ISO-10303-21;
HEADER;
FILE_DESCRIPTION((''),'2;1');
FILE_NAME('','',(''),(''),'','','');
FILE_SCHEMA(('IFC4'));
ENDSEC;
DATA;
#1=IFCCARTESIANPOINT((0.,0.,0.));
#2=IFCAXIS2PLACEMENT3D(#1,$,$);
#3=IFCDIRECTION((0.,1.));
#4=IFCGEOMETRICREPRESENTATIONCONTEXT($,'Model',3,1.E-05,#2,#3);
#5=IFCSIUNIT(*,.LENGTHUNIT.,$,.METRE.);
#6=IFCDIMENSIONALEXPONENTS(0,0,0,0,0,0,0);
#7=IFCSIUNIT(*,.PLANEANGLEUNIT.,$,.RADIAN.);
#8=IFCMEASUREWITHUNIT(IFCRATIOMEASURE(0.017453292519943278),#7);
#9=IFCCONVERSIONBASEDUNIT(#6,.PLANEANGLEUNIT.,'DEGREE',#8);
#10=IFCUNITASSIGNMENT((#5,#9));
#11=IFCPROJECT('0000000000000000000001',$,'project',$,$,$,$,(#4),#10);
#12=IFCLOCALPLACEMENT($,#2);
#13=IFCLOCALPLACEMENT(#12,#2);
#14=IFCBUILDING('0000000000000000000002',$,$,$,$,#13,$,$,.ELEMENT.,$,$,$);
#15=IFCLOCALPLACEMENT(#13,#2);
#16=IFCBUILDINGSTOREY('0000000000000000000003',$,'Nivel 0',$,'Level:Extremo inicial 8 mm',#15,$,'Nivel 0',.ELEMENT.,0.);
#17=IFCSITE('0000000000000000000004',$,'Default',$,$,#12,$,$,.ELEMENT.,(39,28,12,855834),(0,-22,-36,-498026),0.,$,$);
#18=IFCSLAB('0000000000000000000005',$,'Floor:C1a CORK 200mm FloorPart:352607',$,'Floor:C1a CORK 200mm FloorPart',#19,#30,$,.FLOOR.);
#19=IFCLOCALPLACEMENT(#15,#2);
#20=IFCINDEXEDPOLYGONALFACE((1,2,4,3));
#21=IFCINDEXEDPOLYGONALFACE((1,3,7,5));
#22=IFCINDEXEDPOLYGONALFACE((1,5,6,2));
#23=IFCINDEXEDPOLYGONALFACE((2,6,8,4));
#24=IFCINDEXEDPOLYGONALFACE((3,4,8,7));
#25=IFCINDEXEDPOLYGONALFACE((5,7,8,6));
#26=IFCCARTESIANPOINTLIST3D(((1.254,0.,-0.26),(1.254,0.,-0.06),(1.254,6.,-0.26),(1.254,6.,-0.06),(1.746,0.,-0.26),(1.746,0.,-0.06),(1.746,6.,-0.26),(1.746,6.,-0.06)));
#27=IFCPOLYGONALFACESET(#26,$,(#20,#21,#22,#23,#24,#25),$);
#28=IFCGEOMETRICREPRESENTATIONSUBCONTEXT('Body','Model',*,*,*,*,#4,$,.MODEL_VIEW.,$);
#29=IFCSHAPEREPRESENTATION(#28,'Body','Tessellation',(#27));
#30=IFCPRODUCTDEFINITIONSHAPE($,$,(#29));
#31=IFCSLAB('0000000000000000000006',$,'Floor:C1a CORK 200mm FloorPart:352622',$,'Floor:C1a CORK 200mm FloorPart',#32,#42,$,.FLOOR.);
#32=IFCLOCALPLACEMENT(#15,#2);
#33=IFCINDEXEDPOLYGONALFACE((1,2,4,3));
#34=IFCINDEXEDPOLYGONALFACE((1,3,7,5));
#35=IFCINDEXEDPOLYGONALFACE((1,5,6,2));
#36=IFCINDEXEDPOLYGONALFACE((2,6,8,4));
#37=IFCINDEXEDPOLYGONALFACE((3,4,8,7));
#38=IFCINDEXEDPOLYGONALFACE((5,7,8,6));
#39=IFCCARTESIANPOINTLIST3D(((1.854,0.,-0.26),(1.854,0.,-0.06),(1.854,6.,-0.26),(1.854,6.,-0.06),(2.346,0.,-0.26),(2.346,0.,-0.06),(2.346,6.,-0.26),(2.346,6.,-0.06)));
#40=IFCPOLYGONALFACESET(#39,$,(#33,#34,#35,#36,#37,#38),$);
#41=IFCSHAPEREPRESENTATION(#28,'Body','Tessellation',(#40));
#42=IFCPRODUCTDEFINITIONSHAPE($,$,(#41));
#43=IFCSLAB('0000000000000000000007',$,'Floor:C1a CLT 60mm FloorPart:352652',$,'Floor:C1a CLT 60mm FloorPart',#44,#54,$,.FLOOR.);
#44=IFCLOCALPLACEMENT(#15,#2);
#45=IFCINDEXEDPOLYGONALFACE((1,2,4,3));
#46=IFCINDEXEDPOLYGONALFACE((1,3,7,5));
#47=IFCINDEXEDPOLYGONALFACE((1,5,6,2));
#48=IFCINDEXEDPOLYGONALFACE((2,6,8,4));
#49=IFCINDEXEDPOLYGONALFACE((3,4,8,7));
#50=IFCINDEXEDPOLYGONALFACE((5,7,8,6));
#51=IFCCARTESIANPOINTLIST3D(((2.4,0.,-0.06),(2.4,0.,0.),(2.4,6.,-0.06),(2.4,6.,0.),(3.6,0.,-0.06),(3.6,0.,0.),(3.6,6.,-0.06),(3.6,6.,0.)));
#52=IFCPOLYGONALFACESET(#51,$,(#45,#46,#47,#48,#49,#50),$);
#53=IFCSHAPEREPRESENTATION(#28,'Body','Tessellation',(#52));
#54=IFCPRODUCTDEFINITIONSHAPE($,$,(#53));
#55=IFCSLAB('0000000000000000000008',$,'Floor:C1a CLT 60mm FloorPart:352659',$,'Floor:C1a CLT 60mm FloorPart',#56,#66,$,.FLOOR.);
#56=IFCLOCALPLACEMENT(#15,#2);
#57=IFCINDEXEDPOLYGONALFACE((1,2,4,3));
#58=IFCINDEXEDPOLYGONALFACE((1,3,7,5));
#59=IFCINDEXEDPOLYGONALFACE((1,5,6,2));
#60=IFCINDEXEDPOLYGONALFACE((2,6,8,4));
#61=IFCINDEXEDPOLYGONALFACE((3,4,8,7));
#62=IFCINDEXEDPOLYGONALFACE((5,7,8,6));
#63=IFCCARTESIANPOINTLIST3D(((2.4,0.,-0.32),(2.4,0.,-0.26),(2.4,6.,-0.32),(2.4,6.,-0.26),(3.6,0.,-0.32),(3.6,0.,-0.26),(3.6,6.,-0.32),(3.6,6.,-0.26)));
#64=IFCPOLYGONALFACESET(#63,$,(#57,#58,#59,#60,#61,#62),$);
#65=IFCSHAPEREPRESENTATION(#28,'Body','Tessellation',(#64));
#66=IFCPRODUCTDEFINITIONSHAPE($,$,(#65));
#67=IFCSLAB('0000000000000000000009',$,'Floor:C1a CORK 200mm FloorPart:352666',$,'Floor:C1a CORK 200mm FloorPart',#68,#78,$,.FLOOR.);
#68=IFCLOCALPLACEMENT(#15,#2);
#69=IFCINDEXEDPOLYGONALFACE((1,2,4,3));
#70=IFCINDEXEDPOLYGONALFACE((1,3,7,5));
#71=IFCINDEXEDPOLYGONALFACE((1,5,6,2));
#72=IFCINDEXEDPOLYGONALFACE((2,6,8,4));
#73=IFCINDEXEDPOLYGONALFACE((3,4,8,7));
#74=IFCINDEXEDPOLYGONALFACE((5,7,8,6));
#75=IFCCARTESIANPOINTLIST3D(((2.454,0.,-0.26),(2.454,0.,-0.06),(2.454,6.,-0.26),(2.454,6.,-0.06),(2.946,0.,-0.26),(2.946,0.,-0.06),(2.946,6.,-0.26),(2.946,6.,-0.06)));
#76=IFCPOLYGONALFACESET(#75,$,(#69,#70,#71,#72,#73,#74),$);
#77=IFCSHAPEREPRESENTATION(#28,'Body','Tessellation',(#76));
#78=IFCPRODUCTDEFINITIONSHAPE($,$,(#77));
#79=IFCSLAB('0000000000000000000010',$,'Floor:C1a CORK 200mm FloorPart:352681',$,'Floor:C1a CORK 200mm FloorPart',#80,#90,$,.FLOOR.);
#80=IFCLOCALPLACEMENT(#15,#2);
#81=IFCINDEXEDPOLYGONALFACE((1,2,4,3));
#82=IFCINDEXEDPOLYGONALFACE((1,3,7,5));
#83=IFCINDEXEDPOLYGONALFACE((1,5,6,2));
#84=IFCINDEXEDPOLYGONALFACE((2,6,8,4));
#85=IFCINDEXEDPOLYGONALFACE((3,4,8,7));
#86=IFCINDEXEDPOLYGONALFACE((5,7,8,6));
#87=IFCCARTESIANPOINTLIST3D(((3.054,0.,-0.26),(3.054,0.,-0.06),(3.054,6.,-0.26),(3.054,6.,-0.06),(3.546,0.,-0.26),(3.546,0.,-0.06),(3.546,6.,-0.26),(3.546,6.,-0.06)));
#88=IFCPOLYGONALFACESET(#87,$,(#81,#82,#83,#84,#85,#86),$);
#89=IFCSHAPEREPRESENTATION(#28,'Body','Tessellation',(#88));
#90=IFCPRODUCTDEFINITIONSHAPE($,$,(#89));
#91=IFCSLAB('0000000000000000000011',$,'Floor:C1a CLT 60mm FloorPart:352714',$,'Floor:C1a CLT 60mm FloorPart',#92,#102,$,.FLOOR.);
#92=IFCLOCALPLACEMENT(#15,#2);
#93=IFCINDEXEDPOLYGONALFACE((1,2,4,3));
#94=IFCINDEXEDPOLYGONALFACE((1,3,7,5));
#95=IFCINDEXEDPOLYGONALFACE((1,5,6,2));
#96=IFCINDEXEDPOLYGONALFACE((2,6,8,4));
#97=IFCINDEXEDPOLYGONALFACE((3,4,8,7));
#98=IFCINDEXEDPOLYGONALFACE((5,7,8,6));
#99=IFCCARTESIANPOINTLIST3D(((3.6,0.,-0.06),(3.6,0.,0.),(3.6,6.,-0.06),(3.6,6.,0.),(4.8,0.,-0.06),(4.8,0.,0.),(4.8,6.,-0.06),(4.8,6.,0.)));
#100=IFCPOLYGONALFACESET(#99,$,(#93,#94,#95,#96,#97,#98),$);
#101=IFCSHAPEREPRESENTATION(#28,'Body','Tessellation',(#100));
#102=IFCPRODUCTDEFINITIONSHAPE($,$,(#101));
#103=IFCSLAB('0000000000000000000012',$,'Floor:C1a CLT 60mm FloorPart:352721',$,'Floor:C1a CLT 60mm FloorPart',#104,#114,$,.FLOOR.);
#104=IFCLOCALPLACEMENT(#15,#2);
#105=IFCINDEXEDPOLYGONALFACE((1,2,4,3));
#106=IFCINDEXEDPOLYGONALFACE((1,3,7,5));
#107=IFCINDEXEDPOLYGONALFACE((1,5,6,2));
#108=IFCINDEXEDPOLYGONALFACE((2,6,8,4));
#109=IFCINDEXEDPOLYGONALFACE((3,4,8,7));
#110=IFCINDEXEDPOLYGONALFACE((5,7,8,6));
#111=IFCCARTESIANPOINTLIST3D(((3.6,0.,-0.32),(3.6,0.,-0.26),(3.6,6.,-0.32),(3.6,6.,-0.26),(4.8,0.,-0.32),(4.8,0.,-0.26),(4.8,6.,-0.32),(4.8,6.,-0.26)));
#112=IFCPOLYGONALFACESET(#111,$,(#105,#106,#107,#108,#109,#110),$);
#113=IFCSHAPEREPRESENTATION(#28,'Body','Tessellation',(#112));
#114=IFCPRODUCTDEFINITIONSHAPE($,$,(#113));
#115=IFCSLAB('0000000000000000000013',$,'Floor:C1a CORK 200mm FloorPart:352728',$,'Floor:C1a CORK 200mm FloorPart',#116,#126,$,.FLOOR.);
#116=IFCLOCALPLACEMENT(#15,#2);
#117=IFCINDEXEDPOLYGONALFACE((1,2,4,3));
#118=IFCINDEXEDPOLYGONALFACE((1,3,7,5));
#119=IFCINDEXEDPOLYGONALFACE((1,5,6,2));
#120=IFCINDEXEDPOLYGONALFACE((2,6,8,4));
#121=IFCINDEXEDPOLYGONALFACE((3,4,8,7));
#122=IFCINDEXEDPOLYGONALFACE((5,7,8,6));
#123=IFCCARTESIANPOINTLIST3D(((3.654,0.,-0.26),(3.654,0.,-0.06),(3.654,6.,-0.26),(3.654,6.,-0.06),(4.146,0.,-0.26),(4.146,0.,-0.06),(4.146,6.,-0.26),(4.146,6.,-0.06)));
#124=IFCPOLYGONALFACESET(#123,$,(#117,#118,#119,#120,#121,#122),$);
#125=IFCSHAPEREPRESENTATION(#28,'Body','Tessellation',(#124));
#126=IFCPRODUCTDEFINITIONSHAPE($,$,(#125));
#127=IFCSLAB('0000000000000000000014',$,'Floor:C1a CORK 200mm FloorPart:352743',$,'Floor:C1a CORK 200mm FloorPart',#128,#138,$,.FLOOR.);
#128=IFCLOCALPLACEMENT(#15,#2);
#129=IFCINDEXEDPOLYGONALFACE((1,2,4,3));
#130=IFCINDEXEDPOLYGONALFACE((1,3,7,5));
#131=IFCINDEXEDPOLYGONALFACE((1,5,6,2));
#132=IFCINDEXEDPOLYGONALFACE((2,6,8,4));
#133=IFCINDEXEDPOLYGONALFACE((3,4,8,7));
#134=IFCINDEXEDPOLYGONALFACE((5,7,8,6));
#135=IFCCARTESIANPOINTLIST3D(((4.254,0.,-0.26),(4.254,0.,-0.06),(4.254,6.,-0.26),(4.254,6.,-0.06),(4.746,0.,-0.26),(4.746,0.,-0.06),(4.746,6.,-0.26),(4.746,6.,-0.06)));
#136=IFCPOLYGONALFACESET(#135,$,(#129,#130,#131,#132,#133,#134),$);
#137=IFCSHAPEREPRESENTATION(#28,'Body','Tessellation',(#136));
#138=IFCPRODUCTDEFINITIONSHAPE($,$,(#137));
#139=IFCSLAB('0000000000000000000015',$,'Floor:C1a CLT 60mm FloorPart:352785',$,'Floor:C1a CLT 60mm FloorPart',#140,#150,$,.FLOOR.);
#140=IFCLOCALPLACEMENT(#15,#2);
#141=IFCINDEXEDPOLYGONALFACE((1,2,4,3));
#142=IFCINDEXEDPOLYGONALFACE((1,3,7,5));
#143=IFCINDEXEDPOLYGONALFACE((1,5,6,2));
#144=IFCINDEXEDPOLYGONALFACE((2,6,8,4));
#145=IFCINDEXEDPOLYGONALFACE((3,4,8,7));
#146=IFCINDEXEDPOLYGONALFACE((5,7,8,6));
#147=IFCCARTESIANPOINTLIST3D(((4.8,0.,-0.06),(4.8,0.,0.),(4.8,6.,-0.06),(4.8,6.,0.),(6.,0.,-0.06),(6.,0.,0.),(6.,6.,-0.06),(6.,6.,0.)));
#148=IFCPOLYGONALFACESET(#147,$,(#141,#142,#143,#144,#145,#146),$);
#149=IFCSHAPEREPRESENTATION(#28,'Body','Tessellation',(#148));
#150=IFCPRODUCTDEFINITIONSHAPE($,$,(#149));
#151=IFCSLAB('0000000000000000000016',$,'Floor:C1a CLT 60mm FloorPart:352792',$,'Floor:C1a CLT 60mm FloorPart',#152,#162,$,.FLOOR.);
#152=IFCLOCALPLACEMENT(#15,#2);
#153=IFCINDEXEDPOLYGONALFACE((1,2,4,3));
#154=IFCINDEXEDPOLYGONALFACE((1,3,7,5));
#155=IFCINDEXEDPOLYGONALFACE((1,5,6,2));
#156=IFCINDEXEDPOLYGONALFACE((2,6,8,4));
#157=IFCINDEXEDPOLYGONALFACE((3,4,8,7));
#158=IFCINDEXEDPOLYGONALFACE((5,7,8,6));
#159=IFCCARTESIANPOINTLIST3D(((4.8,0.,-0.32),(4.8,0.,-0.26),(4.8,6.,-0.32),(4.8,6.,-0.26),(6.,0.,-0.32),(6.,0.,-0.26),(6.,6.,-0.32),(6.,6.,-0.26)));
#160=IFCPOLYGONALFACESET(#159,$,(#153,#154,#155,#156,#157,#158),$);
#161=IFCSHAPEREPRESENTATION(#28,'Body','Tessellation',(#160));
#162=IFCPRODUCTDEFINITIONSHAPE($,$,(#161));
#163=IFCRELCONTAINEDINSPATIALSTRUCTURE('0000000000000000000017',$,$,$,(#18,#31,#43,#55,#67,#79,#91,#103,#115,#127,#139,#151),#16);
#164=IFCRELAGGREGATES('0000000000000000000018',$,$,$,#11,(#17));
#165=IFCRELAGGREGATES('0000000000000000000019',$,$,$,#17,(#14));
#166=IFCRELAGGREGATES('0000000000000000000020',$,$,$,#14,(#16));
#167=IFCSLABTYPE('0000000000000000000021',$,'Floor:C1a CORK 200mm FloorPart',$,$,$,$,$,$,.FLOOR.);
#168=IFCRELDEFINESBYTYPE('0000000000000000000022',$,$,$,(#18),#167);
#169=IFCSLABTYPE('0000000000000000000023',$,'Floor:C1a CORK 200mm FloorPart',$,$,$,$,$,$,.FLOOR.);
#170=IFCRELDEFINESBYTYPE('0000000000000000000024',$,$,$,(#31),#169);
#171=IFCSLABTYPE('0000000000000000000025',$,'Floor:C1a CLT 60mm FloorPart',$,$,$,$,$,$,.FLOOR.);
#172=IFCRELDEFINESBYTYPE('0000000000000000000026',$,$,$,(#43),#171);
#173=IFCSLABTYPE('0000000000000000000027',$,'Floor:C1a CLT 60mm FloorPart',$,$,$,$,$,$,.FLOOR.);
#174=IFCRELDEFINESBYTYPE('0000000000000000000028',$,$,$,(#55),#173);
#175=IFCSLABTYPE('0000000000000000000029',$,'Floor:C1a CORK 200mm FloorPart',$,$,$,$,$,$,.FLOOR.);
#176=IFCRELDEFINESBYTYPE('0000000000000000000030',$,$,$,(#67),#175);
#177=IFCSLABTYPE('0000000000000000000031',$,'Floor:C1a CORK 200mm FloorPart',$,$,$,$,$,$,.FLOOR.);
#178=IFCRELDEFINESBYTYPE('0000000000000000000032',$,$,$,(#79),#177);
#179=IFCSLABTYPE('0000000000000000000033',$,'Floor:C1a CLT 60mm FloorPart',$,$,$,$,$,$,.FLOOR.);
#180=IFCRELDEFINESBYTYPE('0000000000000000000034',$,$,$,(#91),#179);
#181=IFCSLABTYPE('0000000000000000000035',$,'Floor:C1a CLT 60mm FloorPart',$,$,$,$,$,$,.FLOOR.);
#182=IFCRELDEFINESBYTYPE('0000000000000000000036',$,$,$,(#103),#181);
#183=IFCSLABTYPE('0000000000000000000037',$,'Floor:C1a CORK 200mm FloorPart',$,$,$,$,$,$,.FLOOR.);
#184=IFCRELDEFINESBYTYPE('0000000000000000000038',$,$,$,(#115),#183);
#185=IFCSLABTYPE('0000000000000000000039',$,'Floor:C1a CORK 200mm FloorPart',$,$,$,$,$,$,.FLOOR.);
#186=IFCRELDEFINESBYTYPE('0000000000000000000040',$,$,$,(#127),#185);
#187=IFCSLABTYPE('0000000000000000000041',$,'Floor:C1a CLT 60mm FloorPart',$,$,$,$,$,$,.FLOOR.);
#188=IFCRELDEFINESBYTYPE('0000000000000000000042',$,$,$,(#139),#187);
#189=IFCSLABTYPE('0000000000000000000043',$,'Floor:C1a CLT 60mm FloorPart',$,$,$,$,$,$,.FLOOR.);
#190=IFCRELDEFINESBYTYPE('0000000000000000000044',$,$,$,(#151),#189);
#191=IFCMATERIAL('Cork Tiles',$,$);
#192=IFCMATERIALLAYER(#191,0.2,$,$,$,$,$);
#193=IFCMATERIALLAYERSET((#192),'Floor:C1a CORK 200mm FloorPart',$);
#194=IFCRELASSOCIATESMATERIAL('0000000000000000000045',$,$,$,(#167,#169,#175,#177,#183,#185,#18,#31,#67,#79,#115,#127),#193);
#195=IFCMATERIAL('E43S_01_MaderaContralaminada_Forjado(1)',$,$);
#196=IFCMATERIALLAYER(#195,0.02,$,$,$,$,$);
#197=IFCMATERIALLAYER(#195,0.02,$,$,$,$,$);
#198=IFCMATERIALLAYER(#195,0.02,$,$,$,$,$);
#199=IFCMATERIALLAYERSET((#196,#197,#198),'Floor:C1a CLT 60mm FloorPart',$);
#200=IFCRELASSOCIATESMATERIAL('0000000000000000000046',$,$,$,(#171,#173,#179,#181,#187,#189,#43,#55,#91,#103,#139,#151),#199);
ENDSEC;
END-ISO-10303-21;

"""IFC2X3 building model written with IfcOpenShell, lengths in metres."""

from ifc_helpers import new_model, entity, si_unit, converted_unit, direction, frame, frame_2d, origin, place, context, subcontext, project, spatial, rectangle, extrude, material, layer, layer_set, layer_usage, type_object, element, save


model = new_model("IFC2X3")

# Units and contexts
model_context = context("Model", 3, precision=1e-05, world=origin(), true_north=direction((0.0, 1.0)))
body_context = subcontext(model_context, "Body", "Model", "MODEL_VIEW")
ifc_project = project(units=[si_unit("LENGTHUNIT", "METRE"), converted_unit("PLANEANGLEUNIT", "DEGREE", entity("IfcRatioMeasure", 0.017453292519943278), si_unit("PLANEANGLEUNIT", "RADIAN"), dimensions=[0, 0, 0, 0, 0, 0, 0])], contexts=[model_context])

# Site, building, storey
site_placement = place(None, origin())
site = spatial("IfcSite", under=ifc_project, at=site_placement, Name="Default", CompositionType="ELEMENT", RefLatitude=(39, 28, 12, 855834), RefLongitude=(0, -22, -36, -498026), RefElevation=0.0)
building_placement = place(site_placement, origin())
building = spatial("IfcBuilding", under=site, at=building_placement, CompositionType="ELEMENT")
storey_placement = place(building_placement, origin())
storey = spatial("IfcBuildingStorey", under=building, at=storey_placement, Name="Nivel 0", ObjectType="Level:Extremo inicial 8 mm", LongName="Nivel 0", CompositionType="ELEMENT", Elevation=0.0)

# Shared definitions
ifc_material_1 = material(Name="E43S_01_MaderaContralaminada_Forjado(1)")

# Slabs
ifc_layer_1 = layer(ifc_material_1, 0.02)
ifc_layer_2 = layer(ifc_material_1, 0.02)
ifc_layer_3 = layer(ifc_material_1, 0.02)
ifc_layer_set_1 = layer_set([ifc_layer_1, ifc_layer_2, ifc_layer_3], Name="Floor:C1a CLT 60mm FloorPart")
ifc_material_2 = material(Name="Cork Tiles")
ifc_layer_4 = layer(ifc_material_2, 0.2)
ifc_layer_set_2 = layer_set([ifc_layer_4], Name="Floor:C1a CORK 200mm FloorPart")
ifc_layer_usage_1 = layer_usage(ifc_layer_set_2, "AXIS3", "POSITIVE", 0.0)
slab_type_1 = type_object("IfcSlabType", Name="Floor:C1a CORK 200mm FloorPart", PredefinedType="FLOOR", material=ifc_layer_set_2)
slab_1_placement = place(storey_placement, origin())
element("IfcSlab", 1, at=slab_1_placement, inside=storey, type_object=slab_type_1, material=ifc_layer_usage_1, Name="Floor:C1a CORK 200mm FloorPart:352607", ObjectType="Floor:C1a CORK 200mm FloorPart", PredefinedType="FLOOR", context=body_context, shape_type="SweptSolid", body=[
    extrude(rectangle(XDim=6.0, YDim=0.492, at=frame_2d((0.0, 0.0), x_axis=(1.0, 0.0))), frame((1.5, 3.0, -0.06), z_axis=(0.0, 0.0, -1.0), x_axis=(0.0, 1.0, 0.0)), (0.0, 0.0, 1.0), 0.2),
])
ifc_layer_usage_2 = layer_usage(ifc_layer_set_2, "AXIS3", "POSITIVE", 0.0)
slab_type_2 = type_object("IfcSlabType", Name="Floor:C1a CORK 200mm FloorPart", PredefinedType="FLOOR", material=ifc_layer_set_2)
slab_2_placement = place(storey_placement, origin())
element("IfcSlab", 2, at=slab_2_placement, inside=storey, type_object=slab_type_2, material=ifc_layer_usage_2, Name="Floor:C1a CORK 200mm FloorPart:352622", ObjectType="Floor:C1a CORK 200mm FloorPart", PredefinedType="FLOOR", context=body_context, shape_type="SweptSolid", body=[
    extrude(rectangle(XDim=6.0, YDim=0.492, at=frame_2d((0.0, 0.0), x_axis=(1.0, 0.0))), frame((2.1, 3.0, -0.06), z_axis=(0.0, 0.0, -1.0), x_axis=(0.0, 1.0, 0.0)), (0.0, 0.0, 1.0), 0.2),
])
ifc_layer_usage_3 = layer_usage(ifc_layer_set_1, "AXIS3", "POSITIVE", 0.0)
slab_type_3 = type_object("IfcSlabType", Name="Floor:C1a CLT 60mm FloorPart", PredefinedType="FLOOR", material=ifc_layer_set_1)
slab_3_placement = place(storey_placement, origin())
element("IfcSlab", 3, at=slab_3_placement, inside=storey, type_object=slab_type_3, material=ifc_layer_usage_3, Name="Floor:C1a CLT 60mm FloorPart:352652", ObjectType="Floor:C1a CLT 60mm FloorPart", PredefinedType="FLOOR", context=body_context, shape_type="SweptSolid", body=[
    extrude(rectangle(XDim=6.0, YDim=1.2, at=frame_2d((0.0, 0.0), x_axis=(1.0, 0.0))), frame((3.0, 3.0, 0.0), z_axis=(0.0, 0.0, -1.0), x_axis=(0.0, 1.0, 0.0)), (0.0, 0.0, 1.0), 0.06),
])
ifc_layer_usage_4 = layer_usage(ifc_layer_set_1, "AXIS3", "POSITIVE", 0.0)
slab_type_4 = type_object("IfcSlabType", Name="Floor:C1a CLT 60mm FloorPart", PredefinedType="FLOOR", material=ifc_layer_set_1)
slab_4_placement = place(storey_placement, origin())
element("IfcSlab", 4, at=slab_4_placement, inside=storey, type_object=slab_type_4, material=ifc_layer_usage_4, Name="Floor:C1a CLT 60mm FloorPart:352659", ObjectType="Floor:C1a CLT 60mm FloorPart", PredefinedType="FLOOR", context=body_context, shape_type="SweptSolid", body=[
    extrude(rectangle(XDim=6.0, YDim=1.2, at=frame_2d((0.0, 0.0), x_axis=(1.0, 0.0))), frame((3.0, 3.0, -0.26), z_axis=(0.0, 0.0, -1.0), x_axis=(0.0, 1.0, 0.0)), (0.0, 0.0, 1.0), 0.06),
])
ifc_layer_usage_5 = layer_usage(ifc_layer_set_2, "AXIS3", "POSITIVE", 0.0)
slab_type_5 = type_object("IfcSlabType", Name="Floor:C1a CORK 200mm FloorPart", PredefinedType="FLOOR", material=ifc_layer_set_2)
slab_5_placement = place(storey_placement, origin())
element("IfcSlab", 5, at=slab_5_placement, inside=storey, type_object=slab_type_5, material=ifc_layer_usage_5, Name="Floor:C1a CORK 200mm FloorPart:352666", ObjectType="Floor:C1a CORK 200mm FloorPart", PredefinedType="FLOOR", context=body_context, shape_type="SweptSolid", body=[
    extrude(rectangle(XDim=6.0, YDim=0.492, at=frame_2d((0.0, 0.0), x_axis=(1.0, 0.0))), frame((2.7, 3.0, -0.06), z_axis=(0.0, 0.0, -1.0), x_axis=(0.0, 1.0, 0.0)), (0.0, 0.0, 1.0), 0.2),
])
ifc_layer_usage_6 = layer_usage(ifc_layer_set_2, "AXIS3", "POSITIVE", 0.0)
slab_type_6 = type_object("IfcSlabType", Name="Floor:C1a CORK 200mm FloorPart", PredefinedType="FLOOR", material=ifc_layer_set_2)
slab_6_placement = place(storey_placement, origin())
element("IfcSlab", 6, at=slab_6_placement, inside=storey, type_object=slab_type_6, material=ifc_layer_usage_6, Name="Floor:C1a CORK 200mm FloorPart:352681", ObjectType="Floor:C1a CORK 200mm FloorPart", PredefinedType="FLOOR", context=body_context, shape_type="SweptSolid", body=[
    extrude(rectangle(XDim=6.0, YDim=0.492, at=frame_2d((0.0, 0.0), x_axis=(1.0, 0.0))), frame((3.3, 3.0, -0.06), z_axis=(0.0, 0.0, -1.0), x_axis=(0.0, 1.0, 0.0)), (0.0, 0.0, 1.0), 0.2),
])
ifc_layer_usage_7 = layer_usage(ifc_layer_set_1, "AXIS3", "POSITIVE", 0.0)
slab_type_7 = type_object("IfcSlabType", Name="Floor:C1a CLT 60mm FloorPart", PredefinedType="FLOOR", material=ifc_layer_set_1)
slab_7_placement = place(storey_placement, origin())
element("IfcSlab", 7, at=slab_7_placement, inside=storey, type_object=slab_type_7, material=ifc_layer_usage_7, Name="Floor:C1a CLT 60mm FloorPart:352714", ObjectType="Floor:C1a CLT 60mm FloorPart", PredefinedType="FLOOR", context=body_context, shape_type="SweptSolid", body=[
    extrude(rectangle(XDim=6.0, YDim=1.2, at=frame_2d((0.0, 0.0), x_axis=(1.0, 0.0))), frame((4.2, 3.0, 0.0), z_axis=(0.0, 0.0, -1.0), x_axis=(0.0, 1.0, 0.0)), (0.0, 0.0, 1.0), 0.06),
])
ifc_layer_usage_8 = layer_usage(ifc_layer_set_1, "AXIS3", "POSITIVE", 0.0)
slab_type_8 = type_object("IfcSlabType", Name="Floor:C1a CLT 60mm FloorPart", PredefinedType="FLOOR", material=ifc_layer_set_1)
slab_8_placement = place(storey_placement, origin())
element("IfcSlab", 8, at=slab_8_placement, inside=storey, type_object=slab_type_8, material=ifc_layer_usage_8, Name="Floor:C1a CLT 60mm FloorPart:352721", ObjectType="Floor:C1a CLT 60mm FloorPart", PredefinedType="FLOOR", context=body_context, shape_type="SweptSolid", body=[
    extrude(rectangle(XDim=6.0, YDim=1.2, at=frame_2d((0.0, 0.0), x_axis=(1.0, 0.0))), frame((4.2, 3.0, -0.26), z_axis=(0.0, 0.0, -1.0), x_axis=(0.0, 1.0, 0.0)), (0.0, 0.0, 1.0), 0.06),
])
ifc_layer_usage_9 = layer_usage(ifc_layer_set_2, "AXIS3", "POSITIVE", 0.0)
slab_type_9 = type_object("IfcSlabType", Name="Floor:C1a CORK 200mm FloorPart", PredefinedType="FLOOR", material=ifc_layer_set_2)
slab_9_placement = place(storey_placement, origin())
element("IfcSlab", 9, at=slab_9_placement, inside=storey, type_object=slab_type_9, material=ifc_layer_usage_9, Name="Floor:C1a CORK 200mm FloorPart:352728", ObjectType="Floor:C1a CORK 200mm FloorPart", PredefinedType="FLOOR", context=body_context, shape_type="SweptSolid", body=[
    extrude(rectangle(XDim=6.0, YDim=0.492, at=frame_2d((0.0, 0.0), x_axis=(1.0, 0.0))), frame((3.9, 3.0, -0.06), z_axis=(0.0, 0.0, -1.0), x_axis=(0.0, 1.0, 0.0)), (0.0, 0.0, 1.0), 0.2),
])
ifc_layer_usage_10 = layer_usage(ifc_layer_set_2, "AXIS3", "POSITIVE", 0.0)
slab_type_10 = type_object("IfcSlabType", Name="Floor:C1a CORK 200mm FloorPart", PredefinedType="FLOOR", material=ifc_layer_set_2)
slab_10_placement = place(storey_placement, origin())
element("IfcSlab", 10, at=slab_10_placement, inside=storey, type_object=slab_type_10, material=ifc_layer_usage_10, Name="Floor:C1a CORK 200mm FloorPart:352743", ObjectType="Floor:C1a CORK 200mm FloorPart", PredefinedType="FLOOR", context=body_context, shape_type="SweptSolid", body=[
    extrude(rectangle(XDim=6.0, YDim=0.492, at=frame_2d((0.0, 0.0), x_axis=(1.0, 0.0))), frame((4.5, 3.0, -0.06), z_axis=(0.0, 0.0, -1.0), x_axis=(0.0, 1.0, 0.0)), (0.0, 0.0, 1.0), 0.2),
])
ifc_layer_usage_11 = layer_usage(ifc_layer_set_1, "AXIS3", "POSITIVE", 0.0)
slab_type_11 = type_object("IfcSlabType", Name="Floor:C1a CLT 60mm FloorPart", PredefinedType="FLOOR", material=ifc_layer_set_1)
slab_11_placement = place(storey_placement, origin())
element("IfcSlab", 11, at=slab_11_placement, inside=storey, type_object=slab_type_11, material=ifc_layer_usage_11, Name="Floor:C1a CLT 60mm FloorPart:352785", ObjectType="Floor:C1a CLT 60mm FloorPart", PredefinedType="FLOOR", context=body_context, shape_type="SweptSolid", body=[
    extrude(rectangle(XDim=6.0, YDim=1.2, at=frame_2d((0.0, 0.0), x_axis=(1.0, 0.0))), frame((5.4, 3.0, 0.0), z_axis=(0.0, 0.0, -1.0), x_axis=(0.0, 1.0, 0.0)), (0.0, 0.0, 1.0), 0.06),
])
ifc_layer_usage_12 = layer_usage(ifc_layer_set_1, "AXIS3", "POSITIVE", 0.0)
slab_type_12 = type_object("IfcSlabType", Name="Floor:C1a CLT 60mm FloorPart", PredefinedType="FLOOR", material=ifc_layer_set_1)
slab_12_placement = place(storey_placement, origin())
element("IfcSlab", 12, at=slab_12_placement, inside=storey, type_object=slab_type_12, material=ifc_layer_usage_12, Name="Floor:C1a CLT 60mm FloorPart:352792", ObjectType="Floor:C1a CLT 60mm FloorPart", PredefinedType="FLOOR", context=body_context, shape_type="SweptSolid", body=[
    extrude(rectangle(XDim=6.0, YDim=1.2, at=frame_2d((0.0, 0.0), x_axis=(1.0, 0.0))), frame((5.4, 3.0, -0.26), z_axis=(0.0, 0.0, -1.0), x_axis=(0.0, 1.0, 0.0)), (0.0, 0.0, 1.0), 0.06),
])

save(model, "model.ifc")
